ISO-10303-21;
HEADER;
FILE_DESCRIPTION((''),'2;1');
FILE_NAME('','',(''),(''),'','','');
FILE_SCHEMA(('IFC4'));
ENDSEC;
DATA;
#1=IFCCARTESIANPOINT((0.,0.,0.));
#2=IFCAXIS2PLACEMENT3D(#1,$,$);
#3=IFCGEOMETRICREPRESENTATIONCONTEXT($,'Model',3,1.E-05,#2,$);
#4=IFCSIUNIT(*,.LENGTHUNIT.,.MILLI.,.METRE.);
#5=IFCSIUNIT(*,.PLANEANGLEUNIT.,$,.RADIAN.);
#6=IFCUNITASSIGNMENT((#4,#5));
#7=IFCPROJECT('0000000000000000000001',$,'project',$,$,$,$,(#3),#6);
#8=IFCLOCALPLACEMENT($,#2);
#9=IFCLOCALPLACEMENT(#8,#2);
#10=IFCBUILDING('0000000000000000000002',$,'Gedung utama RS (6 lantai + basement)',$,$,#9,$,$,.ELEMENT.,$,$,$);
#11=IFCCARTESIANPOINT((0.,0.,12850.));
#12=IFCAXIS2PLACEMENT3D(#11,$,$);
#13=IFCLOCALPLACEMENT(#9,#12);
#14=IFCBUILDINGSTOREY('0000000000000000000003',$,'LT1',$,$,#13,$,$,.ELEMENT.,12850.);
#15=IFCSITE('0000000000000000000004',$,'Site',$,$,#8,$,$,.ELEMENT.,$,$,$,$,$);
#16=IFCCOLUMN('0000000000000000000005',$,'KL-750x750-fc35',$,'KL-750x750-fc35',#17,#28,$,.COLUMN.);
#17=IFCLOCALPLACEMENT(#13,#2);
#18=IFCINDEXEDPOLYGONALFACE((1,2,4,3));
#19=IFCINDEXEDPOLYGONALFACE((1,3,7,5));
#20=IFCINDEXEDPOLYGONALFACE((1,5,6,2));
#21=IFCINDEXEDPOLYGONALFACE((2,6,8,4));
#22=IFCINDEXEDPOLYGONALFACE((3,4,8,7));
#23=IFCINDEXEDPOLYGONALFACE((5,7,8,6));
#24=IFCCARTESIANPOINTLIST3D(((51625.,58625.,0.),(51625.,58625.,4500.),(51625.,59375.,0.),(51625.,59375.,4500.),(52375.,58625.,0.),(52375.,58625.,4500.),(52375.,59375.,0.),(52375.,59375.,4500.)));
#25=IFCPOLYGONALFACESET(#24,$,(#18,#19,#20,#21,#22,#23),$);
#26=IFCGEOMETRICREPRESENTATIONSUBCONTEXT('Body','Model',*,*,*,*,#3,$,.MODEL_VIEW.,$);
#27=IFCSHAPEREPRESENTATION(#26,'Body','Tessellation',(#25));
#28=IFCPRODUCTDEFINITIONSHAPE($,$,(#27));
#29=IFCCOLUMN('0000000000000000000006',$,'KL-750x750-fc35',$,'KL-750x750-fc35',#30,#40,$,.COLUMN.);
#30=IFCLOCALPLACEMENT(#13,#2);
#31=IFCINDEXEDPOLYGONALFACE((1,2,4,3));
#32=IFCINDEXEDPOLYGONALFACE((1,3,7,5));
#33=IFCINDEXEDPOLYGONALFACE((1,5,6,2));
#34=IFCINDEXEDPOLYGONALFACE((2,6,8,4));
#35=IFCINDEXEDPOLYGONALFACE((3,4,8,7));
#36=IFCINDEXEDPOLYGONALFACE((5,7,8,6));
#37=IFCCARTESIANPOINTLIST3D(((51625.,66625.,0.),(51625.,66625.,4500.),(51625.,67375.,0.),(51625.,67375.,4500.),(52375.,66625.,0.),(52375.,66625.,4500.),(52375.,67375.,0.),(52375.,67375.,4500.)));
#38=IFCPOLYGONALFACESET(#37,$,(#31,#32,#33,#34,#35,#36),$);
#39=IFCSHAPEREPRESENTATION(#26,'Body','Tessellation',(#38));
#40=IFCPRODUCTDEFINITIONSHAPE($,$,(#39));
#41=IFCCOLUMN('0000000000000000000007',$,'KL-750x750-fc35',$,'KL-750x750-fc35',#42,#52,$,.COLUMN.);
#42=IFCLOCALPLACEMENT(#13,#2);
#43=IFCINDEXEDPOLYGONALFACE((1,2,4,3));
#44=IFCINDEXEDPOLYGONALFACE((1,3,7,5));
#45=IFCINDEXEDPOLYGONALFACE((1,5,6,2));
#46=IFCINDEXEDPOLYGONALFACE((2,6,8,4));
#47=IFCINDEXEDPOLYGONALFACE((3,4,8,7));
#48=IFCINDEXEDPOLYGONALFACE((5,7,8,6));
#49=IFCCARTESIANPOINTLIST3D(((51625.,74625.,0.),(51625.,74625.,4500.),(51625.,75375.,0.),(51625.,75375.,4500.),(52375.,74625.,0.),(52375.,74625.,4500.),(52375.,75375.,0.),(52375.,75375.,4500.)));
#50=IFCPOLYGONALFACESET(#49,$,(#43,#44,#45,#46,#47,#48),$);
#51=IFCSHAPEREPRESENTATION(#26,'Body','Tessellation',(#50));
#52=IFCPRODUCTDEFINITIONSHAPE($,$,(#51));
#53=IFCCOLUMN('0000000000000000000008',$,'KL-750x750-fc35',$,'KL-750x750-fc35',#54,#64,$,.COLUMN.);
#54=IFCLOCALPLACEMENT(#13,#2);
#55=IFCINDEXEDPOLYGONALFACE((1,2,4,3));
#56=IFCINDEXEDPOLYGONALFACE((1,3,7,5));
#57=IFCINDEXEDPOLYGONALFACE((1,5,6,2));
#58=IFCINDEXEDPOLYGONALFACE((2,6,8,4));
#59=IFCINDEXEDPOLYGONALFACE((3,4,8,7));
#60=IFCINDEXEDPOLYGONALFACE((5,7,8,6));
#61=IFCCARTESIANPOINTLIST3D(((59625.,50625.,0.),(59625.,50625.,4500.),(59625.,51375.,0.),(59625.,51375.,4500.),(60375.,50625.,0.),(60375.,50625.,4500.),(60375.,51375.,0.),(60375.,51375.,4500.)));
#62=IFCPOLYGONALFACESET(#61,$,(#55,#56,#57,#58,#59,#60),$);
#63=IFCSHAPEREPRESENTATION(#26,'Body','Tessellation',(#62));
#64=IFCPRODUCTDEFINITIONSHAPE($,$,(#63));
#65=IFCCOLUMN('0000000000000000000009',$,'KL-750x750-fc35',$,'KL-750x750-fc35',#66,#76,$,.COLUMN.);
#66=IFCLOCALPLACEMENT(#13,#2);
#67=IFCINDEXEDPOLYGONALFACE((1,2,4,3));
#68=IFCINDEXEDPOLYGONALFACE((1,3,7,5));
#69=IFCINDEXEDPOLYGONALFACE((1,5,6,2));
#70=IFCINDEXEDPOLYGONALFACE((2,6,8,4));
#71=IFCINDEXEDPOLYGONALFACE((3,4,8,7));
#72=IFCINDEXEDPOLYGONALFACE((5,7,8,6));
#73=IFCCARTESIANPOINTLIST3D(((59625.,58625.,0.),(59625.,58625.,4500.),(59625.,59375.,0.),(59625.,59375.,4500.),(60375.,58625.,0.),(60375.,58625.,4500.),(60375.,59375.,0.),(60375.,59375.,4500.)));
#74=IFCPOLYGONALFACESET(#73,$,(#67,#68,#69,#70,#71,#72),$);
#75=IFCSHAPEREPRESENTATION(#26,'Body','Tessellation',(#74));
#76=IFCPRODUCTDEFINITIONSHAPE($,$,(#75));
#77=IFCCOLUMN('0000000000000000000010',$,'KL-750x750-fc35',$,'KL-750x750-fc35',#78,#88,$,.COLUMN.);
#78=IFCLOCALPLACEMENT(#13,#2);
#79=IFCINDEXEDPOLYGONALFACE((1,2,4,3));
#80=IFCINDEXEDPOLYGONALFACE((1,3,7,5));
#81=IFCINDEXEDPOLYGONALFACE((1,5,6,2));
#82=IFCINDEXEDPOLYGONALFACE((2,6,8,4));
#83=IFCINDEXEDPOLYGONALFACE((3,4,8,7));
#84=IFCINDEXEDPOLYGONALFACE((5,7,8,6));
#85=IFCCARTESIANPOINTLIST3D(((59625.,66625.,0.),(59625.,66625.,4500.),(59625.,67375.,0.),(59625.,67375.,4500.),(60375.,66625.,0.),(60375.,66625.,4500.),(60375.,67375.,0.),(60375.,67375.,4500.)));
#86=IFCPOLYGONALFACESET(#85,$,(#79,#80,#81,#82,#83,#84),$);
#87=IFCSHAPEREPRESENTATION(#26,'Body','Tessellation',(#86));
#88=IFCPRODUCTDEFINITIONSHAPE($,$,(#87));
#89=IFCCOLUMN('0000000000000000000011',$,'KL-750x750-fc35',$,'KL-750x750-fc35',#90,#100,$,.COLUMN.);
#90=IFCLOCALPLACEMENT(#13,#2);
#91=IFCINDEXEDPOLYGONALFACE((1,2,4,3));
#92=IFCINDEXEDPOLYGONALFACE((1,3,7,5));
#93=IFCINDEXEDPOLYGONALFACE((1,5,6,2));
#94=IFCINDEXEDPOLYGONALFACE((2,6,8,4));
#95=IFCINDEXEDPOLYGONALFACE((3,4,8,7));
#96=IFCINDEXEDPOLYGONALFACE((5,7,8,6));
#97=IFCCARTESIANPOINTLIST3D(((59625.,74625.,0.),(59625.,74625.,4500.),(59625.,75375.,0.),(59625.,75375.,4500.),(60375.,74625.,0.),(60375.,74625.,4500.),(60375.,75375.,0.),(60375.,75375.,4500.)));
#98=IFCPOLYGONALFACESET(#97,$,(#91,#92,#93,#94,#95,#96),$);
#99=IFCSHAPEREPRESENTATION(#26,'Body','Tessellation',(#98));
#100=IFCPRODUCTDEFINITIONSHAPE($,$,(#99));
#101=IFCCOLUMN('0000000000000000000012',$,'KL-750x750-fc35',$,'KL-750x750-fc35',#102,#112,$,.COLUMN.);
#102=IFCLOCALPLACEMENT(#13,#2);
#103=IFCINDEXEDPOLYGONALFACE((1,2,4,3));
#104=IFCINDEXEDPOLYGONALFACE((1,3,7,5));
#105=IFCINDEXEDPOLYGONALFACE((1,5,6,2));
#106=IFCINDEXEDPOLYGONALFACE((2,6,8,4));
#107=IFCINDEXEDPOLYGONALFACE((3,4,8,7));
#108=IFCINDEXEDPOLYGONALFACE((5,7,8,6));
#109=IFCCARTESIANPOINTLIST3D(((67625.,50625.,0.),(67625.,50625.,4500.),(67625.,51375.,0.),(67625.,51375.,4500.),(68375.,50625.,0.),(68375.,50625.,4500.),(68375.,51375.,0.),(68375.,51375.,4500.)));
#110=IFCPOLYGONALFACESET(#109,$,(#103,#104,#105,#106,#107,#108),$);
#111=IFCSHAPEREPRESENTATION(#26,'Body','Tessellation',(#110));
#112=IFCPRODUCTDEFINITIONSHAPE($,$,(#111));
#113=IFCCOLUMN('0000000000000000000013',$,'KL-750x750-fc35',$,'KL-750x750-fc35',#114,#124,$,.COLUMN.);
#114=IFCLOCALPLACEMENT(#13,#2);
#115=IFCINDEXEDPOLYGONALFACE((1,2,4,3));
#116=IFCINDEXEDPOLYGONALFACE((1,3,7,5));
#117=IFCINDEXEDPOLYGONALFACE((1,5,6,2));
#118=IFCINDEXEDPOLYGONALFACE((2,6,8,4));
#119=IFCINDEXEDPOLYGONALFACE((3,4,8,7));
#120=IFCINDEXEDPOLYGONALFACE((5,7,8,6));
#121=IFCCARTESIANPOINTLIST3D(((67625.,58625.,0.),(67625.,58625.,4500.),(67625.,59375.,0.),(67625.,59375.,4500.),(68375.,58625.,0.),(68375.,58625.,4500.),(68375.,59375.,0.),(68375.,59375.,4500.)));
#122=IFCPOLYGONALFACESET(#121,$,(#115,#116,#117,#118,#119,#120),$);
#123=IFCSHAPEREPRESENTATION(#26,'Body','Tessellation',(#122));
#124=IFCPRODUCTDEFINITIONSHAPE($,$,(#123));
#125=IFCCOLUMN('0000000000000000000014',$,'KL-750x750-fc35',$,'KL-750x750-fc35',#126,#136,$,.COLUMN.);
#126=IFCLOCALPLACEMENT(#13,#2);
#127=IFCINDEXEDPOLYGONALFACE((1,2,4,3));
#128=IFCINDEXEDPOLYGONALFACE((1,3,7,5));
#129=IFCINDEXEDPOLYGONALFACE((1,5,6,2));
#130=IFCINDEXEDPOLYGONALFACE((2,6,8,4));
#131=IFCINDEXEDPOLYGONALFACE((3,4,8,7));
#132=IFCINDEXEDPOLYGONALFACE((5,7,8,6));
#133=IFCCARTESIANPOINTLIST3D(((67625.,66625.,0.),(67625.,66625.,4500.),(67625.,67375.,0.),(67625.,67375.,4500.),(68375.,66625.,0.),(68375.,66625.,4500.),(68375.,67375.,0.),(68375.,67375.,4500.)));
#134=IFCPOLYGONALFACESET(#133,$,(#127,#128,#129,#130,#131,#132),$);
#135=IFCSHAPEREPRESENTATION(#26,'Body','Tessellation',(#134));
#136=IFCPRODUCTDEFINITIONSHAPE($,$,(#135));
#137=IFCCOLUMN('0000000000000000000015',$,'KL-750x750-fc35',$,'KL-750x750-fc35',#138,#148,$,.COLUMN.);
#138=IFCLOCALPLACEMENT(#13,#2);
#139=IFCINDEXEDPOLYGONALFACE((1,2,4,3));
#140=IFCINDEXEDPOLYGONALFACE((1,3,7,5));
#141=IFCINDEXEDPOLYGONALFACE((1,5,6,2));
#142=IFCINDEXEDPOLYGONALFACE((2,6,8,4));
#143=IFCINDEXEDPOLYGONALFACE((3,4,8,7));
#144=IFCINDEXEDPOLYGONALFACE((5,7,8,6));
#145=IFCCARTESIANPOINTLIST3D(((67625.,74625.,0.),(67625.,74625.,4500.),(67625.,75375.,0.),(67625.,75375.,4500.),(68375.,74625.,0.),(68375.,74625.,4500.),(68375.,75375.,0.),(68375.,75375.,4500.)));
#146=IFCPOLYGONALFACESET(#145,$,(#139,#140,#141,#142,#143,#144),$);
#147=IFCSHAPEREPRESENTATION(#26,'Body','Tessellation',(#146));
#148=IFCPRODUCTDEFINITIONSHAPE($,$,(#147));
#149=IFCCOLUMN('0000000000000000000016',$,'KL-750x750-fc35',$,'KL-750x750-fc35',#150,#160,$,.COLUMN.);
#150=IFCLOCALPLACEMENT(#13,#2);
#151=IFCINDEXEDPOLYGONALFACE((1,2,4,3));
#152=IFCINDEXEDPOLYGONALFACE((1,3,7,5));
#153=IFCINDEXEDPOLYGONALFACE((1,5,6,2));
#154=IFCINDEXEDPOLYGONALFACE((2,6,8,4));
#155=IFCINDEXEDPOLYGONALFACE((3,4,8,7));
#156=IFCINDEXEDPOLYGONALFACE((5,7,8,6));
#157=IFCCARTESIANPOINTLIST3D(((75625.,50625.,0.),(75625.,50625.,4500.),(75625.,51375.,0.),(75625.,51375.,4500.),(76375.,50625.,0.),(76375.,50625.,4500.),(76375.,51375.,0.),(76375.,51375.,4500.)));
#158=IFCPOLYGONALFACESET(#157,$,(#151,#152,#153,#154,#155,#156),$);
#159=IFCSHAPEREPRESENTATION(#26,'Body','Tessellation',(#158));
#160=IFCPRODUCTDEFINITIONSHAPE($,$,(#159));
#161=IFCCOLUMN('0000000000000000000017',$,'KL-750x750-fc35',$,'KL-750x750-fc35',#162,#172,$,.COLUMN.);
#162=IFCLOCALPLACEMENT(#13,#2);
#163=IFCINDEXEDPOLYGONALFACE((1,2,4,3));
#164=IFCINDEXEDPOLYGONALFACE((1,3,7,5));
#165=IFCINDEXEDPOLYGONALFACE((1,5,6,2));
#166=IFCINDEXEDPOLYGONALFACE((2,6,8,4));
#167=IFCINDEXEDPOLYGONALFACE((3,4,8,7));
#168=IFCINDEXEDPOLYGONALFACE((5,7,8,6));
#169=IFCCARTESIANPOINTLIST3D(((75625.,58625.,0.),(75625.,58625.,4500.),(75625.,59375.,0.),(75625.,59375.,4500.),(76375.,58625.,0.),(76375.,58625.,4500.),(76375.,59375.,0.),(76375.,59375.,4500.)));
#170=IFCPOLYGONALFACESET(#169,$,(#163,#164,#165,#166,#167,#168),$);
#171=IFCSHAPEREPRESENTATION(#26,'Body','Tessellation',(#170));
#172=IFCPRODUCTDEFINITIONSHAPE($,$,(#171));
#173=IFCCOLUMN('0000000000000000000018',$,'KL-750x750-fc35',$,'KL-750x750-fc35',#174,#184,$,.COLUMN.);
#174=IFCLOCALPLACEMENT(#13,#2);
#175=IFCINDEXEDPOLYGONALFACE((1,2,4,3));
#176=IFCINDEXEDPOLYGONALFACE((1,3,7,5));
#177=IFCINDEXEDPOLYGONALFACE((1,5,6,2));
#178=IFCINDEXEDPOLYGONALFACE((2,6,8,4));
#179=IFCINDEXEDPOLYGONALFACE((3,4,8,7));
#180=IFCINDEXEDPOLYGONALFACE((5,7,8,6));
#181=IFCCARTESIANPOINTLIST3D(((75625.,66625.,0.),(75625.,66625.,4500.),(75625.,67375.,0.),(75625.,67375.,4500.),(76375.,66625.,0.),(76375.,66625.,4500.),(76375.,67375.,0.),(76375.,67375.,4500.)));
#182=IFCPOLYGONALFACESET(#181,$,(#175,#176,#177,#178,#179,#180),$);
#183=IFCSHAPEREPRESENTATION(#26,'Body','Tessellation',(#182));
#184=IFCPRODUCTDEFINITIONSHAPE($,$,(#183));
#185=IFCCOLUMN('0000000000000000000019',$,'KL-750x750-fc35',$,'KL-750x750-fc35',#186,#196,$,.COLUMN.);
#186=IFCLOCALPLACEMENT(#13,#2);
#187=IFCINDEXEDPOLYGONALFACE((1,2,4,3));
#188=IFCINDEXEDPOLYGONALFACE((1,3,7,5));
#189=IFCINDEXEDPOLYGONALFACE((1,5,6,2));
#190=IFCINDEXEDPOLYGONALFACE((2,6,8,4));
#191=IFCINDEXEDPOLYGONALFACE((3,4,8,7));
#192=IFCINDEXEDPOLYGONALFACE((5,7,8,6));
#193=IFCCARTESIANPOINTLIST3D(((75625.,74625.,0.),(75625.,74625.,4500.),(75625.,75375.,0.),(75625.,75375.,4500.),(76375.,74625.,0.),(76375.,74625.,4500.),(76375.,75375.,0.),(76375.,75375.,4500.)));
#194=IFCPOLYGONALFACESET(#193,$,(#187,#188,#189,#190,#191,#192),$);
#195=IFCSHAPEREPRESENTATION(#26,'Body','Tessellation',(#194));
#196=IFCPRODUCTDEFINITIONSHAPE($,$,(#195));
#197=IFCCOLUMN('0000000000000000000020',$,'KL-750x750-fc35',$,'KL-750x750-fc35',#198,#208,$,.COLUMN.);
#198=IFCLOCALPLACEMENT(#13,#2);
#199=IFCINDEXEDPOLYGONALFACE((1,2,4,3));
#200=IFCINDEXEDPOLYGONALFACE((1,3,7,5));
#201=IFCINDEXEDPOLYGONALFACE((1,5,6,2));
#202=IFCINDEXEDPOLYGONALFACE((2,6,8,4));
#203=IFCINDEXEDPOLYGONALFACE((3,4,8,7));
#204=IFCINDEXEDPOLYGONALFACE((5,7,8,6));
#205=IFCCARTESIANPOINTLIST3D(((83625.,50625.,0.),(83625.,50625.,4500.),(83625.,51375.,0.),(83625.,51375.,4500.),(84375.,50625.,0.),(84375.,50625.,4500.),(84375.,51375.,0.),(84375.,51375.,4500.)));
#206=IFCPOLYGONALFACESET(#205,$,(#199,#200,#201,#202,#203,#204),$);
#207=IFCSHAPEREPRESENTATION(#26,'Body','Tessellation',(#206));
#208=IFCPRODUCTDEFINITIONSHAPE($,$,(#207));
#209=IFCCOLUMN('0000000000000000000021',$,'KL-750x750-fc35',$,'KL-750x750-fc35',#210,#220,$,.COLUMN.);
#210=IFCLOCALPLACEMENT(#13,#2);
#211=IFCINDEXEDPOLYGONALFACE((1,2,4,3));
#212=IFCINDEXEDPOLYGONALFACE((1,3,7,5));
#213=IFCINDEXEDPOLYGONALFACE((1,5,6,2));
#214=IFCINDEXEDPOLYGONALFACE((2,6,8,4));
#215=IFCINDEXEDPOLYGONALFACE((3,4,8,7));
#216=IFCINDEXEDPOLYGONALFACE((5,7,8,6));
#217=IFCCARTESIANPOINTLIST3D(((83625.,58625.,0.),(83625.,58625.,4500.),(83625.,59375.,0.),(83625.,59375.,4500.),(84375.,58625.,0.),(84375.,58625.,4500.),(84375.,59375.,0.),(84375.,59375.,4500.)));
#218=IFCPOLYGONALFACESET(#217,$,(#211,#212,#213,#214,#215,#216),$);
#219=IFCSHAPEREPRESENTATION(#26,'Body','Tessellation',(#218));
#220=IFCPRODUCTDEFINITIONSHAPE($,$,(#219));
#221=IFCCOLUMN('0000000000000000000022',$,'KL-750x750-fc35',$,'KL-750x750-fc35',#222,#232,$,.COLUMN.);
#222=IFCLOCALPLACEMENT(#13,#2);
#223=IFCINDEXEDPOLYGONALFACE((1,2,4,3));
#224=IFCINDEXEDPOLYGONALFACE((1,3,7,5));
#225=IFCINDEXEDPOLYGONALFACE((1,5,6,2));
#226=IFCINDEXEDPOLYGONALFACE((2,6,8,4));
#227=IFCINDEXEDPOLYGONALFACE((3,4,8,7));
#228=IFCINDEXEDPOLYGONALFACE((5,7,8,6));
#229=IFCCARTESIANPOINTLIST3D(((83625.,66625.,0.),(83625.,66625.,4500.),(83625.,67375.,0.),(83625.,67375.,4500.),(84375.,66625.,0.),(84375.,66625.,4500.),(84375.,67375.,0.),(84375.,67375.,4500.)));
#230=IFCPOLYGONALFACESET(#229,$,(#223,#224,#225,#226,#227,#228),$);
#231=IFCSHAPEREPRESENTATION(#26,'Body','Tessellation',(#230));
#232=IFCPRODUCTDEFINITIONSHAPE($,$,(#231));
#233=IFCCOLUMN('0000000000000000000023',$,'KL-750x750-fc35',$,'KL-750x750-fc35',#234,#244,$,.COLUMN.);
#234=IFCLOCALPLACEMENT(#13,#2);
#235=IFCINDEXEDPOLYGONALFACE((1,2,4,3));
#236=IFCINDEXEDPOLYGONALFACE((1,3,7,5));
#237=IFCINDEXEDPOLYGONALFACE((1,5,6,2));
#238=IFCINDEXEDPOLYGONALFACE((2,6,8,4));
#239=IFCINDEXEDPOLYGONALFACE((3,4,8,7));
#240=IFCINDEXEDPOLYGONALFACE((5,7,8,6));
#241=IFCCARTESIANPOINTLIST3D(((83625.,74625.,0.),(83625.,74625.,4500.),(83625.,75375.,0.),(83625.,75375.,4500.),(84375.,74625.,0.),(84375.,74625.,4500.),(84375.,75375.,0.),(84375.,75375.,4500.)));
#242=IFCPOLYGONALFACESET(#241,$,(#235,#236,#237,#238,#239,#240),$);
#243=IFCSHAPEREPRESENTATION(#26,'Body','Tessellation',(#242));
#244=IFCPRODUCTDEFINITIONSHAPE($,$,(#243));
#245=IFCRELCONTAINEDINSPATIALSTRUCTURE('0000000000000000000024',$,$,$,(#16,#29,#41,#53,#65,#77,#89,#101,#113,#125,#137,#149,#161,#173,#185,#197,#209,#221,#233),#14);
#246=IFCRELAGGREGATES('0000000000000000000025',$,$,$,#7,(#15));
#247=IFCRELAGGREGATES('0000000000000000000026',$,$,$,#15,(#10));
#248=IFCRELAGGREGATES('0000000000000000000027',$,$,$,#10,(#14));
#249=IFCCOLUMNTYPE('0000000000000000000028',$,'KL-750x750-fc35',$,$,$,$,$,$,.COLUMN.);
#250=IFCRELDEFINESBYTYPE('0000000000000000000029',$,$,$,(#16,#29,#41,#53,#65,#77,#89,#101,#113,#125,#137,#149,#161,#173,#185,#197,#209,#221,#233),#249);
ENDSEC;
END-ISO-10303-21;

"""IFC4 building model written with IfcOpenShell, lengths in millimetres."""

from ifc_helpers import new_model, si_unit, frame, origin, origin_2d, place, context, subcontext, project, spatial, rectangle, extrude, material_profile, profile_set, profile_usage, type_object, element, save


model = new_model("IFC4")

# Units and contexts
model_context = context("Model", 3, precision=1e-05, world=origin())
body_context = subcontext(model_context, "Body", "Model", "MODEL_VIEW")
ifc_project = project(units=[si_unit("LENGTHUNIT", "METRE", prefix="MILLI"), si_unit("PLANEANGLEUNIT", "RADIAN")], contexts=[model_context])

# Site, building, storey
site_placement = place(None, origin())
site = spatial("IfcSite", under=ifc_project, at=site_placement, Name="Site", CompositionType="ELEMENT")
building_placement = place(site_placement, origin())
building = spatial("IfcBuilding", under=site, at=building_placement, Name="Gedung utama RS (6 lantai + basement)", CompositionType="ELEMENT")
storey_placement = place(building_placement, frame((0.0, 0.0, 12850.0)))
storey = spatial("IfcBuildingStorey", under=building, at=storey_placement, Name="LT1", CompositionType="ELEMENT", Elevation=12850.0)

# Columns
ifc_material_profile = material_profile(None, rectangle(XDim=750.0, YDim=750.0, at=origin_2d()), Name="KL-750x750-fc35")
ifc_profile_set = profile_set([ifc_material_profile], Name="KL-750x750-fc35")
ifc_profile_usage = profile_usage(ifc_profile_set, cardinal=5)
column_type = type_object("IfcColumnType", Name="KL-750x750-fc35", PredefinedType="COLUMN", material=ifc_profile_set)
for number, where, z_axis, x_axis, name in (
    (1, (52000.0, 59000.0, 0.0), (0.0, 0.0, 1.0), (1.0, 0.0, 0.0), "KL-750x750-fc35"),
    (2, (52000.0, 67000.0, 0.0), (0.0, 0.0, 1.0), (1.0, 0.0, 0.0), "KL-750x750-fc35"),
    (3, (52000.0, 75000.0, 0.0), (0.0, 0.0, 1.0), (1.0, 0.0, 0.0), "KL-750x750-fc35"),
    (4, (60000.0, 51000.0, 0.0), (0.0, 0.0, 1.0), (1.0, 0.0, 0.0), "KL-750x750-fc35"),
    (5, (60000.0, 59000.0, 0.0), (0.0, 0.0, 1.0), (1.0, 0.0, 0.0), "KL-750x750-fc35"),
    (6, (60000.0, 67000.0, 0.0), (0.0, 0.0, 1.0), (1.0, 0.0, 0.0), "KL-750x750-fc35"),
    (7, (60000.0, 75000.0, 0.0), (0.0, 0.0, 1.0), (1.0, 0.0, 0.0), "KL-750x750-fc35"),
    (8, (68000.0, 51000.0, 0.0), (0.0, 0.0, 1.0), (1.0, 0.0, 0.0), "KL-750x750-fc35"),
    (9, (68000.0, 59000.0, 0.0), (0.0, 0.0, 1.0), (1.0, 0.0, 0.0), "KL-750x750-fc35"),
    (10, (68000.0, 67000.0, 0.0), (0.0, 0.0, 1.0), (1.0, 0.0, 0.0), "KL-750x750-fc35"),
    (11, (68000.0, 75000.0, 0.0), (0.0, 0.0, 1.0), (1.0, 0.0, 0.0), "KL-750x750-fc35"),
    (12, (76000.0, 51000.0, 0.0), (0.0, 0.0, 1.0), (1.0, 0.0, 0.0), "KL-750x750-fc35"),
    (13, (76000.0, 59000.0, 0.0), (0.0, 0.0, 1.0), (1.0, 0.0, 0.0), "KL-750x750-fc35"),
    (14, (76000.0, 67000.0, 0.0), (0.0, 0.0, 1.0), (1.0, 0.0, 0.0), "KL-750x750-fc35"),
    (15, (76000.0, 75000.0, 0.0), (0.0, 0.0, 1.0), (1.0, 0.0, 0.0), "KL-750x750-fc35"),
    (16, (84000.0, 51000.0, 0.0), (0.0, 0.0, 1.0), (1.0, 0.0, 0.0), "KL-750x750-fc35"),
    (17, (84000.0, 59000.0, 0.0), (0.0, 0.0, 1.0), (1.0, 0.0, 0.0), "KL-750x750-fc35"),
    (18, (84000.0, 67000.0, 0.0), (0.0, 0.0, 1.0), (1.0, 0.0, 0.0), "KL-750x750-fc35"),
    (19, (84000.0, 75000.0, 0.0), (0.0, 0.0, 1.0), (1.0, 0.0, 0.0), "KL-750x750-fc35"),
):
    element("IfcColumn", number, at=place(storey_placement, frame(where, z_axis=z_axis, x_axis=x_axis)), inside=storey, type_object=column_type, material=ifc_profile_usage, Name=name, ObjectType="KL-750x750-fc35", PredefinedType="COLUMN", context=body_context, shape_type="SweptSolid", body=[
        extrude(rectangle(XDim=750.0, YDim=750.0, at=origin_2d()), origin(), (0.0, 0.0, 1.0), 4500.0),
    ])

save(model, "model.ifc")
